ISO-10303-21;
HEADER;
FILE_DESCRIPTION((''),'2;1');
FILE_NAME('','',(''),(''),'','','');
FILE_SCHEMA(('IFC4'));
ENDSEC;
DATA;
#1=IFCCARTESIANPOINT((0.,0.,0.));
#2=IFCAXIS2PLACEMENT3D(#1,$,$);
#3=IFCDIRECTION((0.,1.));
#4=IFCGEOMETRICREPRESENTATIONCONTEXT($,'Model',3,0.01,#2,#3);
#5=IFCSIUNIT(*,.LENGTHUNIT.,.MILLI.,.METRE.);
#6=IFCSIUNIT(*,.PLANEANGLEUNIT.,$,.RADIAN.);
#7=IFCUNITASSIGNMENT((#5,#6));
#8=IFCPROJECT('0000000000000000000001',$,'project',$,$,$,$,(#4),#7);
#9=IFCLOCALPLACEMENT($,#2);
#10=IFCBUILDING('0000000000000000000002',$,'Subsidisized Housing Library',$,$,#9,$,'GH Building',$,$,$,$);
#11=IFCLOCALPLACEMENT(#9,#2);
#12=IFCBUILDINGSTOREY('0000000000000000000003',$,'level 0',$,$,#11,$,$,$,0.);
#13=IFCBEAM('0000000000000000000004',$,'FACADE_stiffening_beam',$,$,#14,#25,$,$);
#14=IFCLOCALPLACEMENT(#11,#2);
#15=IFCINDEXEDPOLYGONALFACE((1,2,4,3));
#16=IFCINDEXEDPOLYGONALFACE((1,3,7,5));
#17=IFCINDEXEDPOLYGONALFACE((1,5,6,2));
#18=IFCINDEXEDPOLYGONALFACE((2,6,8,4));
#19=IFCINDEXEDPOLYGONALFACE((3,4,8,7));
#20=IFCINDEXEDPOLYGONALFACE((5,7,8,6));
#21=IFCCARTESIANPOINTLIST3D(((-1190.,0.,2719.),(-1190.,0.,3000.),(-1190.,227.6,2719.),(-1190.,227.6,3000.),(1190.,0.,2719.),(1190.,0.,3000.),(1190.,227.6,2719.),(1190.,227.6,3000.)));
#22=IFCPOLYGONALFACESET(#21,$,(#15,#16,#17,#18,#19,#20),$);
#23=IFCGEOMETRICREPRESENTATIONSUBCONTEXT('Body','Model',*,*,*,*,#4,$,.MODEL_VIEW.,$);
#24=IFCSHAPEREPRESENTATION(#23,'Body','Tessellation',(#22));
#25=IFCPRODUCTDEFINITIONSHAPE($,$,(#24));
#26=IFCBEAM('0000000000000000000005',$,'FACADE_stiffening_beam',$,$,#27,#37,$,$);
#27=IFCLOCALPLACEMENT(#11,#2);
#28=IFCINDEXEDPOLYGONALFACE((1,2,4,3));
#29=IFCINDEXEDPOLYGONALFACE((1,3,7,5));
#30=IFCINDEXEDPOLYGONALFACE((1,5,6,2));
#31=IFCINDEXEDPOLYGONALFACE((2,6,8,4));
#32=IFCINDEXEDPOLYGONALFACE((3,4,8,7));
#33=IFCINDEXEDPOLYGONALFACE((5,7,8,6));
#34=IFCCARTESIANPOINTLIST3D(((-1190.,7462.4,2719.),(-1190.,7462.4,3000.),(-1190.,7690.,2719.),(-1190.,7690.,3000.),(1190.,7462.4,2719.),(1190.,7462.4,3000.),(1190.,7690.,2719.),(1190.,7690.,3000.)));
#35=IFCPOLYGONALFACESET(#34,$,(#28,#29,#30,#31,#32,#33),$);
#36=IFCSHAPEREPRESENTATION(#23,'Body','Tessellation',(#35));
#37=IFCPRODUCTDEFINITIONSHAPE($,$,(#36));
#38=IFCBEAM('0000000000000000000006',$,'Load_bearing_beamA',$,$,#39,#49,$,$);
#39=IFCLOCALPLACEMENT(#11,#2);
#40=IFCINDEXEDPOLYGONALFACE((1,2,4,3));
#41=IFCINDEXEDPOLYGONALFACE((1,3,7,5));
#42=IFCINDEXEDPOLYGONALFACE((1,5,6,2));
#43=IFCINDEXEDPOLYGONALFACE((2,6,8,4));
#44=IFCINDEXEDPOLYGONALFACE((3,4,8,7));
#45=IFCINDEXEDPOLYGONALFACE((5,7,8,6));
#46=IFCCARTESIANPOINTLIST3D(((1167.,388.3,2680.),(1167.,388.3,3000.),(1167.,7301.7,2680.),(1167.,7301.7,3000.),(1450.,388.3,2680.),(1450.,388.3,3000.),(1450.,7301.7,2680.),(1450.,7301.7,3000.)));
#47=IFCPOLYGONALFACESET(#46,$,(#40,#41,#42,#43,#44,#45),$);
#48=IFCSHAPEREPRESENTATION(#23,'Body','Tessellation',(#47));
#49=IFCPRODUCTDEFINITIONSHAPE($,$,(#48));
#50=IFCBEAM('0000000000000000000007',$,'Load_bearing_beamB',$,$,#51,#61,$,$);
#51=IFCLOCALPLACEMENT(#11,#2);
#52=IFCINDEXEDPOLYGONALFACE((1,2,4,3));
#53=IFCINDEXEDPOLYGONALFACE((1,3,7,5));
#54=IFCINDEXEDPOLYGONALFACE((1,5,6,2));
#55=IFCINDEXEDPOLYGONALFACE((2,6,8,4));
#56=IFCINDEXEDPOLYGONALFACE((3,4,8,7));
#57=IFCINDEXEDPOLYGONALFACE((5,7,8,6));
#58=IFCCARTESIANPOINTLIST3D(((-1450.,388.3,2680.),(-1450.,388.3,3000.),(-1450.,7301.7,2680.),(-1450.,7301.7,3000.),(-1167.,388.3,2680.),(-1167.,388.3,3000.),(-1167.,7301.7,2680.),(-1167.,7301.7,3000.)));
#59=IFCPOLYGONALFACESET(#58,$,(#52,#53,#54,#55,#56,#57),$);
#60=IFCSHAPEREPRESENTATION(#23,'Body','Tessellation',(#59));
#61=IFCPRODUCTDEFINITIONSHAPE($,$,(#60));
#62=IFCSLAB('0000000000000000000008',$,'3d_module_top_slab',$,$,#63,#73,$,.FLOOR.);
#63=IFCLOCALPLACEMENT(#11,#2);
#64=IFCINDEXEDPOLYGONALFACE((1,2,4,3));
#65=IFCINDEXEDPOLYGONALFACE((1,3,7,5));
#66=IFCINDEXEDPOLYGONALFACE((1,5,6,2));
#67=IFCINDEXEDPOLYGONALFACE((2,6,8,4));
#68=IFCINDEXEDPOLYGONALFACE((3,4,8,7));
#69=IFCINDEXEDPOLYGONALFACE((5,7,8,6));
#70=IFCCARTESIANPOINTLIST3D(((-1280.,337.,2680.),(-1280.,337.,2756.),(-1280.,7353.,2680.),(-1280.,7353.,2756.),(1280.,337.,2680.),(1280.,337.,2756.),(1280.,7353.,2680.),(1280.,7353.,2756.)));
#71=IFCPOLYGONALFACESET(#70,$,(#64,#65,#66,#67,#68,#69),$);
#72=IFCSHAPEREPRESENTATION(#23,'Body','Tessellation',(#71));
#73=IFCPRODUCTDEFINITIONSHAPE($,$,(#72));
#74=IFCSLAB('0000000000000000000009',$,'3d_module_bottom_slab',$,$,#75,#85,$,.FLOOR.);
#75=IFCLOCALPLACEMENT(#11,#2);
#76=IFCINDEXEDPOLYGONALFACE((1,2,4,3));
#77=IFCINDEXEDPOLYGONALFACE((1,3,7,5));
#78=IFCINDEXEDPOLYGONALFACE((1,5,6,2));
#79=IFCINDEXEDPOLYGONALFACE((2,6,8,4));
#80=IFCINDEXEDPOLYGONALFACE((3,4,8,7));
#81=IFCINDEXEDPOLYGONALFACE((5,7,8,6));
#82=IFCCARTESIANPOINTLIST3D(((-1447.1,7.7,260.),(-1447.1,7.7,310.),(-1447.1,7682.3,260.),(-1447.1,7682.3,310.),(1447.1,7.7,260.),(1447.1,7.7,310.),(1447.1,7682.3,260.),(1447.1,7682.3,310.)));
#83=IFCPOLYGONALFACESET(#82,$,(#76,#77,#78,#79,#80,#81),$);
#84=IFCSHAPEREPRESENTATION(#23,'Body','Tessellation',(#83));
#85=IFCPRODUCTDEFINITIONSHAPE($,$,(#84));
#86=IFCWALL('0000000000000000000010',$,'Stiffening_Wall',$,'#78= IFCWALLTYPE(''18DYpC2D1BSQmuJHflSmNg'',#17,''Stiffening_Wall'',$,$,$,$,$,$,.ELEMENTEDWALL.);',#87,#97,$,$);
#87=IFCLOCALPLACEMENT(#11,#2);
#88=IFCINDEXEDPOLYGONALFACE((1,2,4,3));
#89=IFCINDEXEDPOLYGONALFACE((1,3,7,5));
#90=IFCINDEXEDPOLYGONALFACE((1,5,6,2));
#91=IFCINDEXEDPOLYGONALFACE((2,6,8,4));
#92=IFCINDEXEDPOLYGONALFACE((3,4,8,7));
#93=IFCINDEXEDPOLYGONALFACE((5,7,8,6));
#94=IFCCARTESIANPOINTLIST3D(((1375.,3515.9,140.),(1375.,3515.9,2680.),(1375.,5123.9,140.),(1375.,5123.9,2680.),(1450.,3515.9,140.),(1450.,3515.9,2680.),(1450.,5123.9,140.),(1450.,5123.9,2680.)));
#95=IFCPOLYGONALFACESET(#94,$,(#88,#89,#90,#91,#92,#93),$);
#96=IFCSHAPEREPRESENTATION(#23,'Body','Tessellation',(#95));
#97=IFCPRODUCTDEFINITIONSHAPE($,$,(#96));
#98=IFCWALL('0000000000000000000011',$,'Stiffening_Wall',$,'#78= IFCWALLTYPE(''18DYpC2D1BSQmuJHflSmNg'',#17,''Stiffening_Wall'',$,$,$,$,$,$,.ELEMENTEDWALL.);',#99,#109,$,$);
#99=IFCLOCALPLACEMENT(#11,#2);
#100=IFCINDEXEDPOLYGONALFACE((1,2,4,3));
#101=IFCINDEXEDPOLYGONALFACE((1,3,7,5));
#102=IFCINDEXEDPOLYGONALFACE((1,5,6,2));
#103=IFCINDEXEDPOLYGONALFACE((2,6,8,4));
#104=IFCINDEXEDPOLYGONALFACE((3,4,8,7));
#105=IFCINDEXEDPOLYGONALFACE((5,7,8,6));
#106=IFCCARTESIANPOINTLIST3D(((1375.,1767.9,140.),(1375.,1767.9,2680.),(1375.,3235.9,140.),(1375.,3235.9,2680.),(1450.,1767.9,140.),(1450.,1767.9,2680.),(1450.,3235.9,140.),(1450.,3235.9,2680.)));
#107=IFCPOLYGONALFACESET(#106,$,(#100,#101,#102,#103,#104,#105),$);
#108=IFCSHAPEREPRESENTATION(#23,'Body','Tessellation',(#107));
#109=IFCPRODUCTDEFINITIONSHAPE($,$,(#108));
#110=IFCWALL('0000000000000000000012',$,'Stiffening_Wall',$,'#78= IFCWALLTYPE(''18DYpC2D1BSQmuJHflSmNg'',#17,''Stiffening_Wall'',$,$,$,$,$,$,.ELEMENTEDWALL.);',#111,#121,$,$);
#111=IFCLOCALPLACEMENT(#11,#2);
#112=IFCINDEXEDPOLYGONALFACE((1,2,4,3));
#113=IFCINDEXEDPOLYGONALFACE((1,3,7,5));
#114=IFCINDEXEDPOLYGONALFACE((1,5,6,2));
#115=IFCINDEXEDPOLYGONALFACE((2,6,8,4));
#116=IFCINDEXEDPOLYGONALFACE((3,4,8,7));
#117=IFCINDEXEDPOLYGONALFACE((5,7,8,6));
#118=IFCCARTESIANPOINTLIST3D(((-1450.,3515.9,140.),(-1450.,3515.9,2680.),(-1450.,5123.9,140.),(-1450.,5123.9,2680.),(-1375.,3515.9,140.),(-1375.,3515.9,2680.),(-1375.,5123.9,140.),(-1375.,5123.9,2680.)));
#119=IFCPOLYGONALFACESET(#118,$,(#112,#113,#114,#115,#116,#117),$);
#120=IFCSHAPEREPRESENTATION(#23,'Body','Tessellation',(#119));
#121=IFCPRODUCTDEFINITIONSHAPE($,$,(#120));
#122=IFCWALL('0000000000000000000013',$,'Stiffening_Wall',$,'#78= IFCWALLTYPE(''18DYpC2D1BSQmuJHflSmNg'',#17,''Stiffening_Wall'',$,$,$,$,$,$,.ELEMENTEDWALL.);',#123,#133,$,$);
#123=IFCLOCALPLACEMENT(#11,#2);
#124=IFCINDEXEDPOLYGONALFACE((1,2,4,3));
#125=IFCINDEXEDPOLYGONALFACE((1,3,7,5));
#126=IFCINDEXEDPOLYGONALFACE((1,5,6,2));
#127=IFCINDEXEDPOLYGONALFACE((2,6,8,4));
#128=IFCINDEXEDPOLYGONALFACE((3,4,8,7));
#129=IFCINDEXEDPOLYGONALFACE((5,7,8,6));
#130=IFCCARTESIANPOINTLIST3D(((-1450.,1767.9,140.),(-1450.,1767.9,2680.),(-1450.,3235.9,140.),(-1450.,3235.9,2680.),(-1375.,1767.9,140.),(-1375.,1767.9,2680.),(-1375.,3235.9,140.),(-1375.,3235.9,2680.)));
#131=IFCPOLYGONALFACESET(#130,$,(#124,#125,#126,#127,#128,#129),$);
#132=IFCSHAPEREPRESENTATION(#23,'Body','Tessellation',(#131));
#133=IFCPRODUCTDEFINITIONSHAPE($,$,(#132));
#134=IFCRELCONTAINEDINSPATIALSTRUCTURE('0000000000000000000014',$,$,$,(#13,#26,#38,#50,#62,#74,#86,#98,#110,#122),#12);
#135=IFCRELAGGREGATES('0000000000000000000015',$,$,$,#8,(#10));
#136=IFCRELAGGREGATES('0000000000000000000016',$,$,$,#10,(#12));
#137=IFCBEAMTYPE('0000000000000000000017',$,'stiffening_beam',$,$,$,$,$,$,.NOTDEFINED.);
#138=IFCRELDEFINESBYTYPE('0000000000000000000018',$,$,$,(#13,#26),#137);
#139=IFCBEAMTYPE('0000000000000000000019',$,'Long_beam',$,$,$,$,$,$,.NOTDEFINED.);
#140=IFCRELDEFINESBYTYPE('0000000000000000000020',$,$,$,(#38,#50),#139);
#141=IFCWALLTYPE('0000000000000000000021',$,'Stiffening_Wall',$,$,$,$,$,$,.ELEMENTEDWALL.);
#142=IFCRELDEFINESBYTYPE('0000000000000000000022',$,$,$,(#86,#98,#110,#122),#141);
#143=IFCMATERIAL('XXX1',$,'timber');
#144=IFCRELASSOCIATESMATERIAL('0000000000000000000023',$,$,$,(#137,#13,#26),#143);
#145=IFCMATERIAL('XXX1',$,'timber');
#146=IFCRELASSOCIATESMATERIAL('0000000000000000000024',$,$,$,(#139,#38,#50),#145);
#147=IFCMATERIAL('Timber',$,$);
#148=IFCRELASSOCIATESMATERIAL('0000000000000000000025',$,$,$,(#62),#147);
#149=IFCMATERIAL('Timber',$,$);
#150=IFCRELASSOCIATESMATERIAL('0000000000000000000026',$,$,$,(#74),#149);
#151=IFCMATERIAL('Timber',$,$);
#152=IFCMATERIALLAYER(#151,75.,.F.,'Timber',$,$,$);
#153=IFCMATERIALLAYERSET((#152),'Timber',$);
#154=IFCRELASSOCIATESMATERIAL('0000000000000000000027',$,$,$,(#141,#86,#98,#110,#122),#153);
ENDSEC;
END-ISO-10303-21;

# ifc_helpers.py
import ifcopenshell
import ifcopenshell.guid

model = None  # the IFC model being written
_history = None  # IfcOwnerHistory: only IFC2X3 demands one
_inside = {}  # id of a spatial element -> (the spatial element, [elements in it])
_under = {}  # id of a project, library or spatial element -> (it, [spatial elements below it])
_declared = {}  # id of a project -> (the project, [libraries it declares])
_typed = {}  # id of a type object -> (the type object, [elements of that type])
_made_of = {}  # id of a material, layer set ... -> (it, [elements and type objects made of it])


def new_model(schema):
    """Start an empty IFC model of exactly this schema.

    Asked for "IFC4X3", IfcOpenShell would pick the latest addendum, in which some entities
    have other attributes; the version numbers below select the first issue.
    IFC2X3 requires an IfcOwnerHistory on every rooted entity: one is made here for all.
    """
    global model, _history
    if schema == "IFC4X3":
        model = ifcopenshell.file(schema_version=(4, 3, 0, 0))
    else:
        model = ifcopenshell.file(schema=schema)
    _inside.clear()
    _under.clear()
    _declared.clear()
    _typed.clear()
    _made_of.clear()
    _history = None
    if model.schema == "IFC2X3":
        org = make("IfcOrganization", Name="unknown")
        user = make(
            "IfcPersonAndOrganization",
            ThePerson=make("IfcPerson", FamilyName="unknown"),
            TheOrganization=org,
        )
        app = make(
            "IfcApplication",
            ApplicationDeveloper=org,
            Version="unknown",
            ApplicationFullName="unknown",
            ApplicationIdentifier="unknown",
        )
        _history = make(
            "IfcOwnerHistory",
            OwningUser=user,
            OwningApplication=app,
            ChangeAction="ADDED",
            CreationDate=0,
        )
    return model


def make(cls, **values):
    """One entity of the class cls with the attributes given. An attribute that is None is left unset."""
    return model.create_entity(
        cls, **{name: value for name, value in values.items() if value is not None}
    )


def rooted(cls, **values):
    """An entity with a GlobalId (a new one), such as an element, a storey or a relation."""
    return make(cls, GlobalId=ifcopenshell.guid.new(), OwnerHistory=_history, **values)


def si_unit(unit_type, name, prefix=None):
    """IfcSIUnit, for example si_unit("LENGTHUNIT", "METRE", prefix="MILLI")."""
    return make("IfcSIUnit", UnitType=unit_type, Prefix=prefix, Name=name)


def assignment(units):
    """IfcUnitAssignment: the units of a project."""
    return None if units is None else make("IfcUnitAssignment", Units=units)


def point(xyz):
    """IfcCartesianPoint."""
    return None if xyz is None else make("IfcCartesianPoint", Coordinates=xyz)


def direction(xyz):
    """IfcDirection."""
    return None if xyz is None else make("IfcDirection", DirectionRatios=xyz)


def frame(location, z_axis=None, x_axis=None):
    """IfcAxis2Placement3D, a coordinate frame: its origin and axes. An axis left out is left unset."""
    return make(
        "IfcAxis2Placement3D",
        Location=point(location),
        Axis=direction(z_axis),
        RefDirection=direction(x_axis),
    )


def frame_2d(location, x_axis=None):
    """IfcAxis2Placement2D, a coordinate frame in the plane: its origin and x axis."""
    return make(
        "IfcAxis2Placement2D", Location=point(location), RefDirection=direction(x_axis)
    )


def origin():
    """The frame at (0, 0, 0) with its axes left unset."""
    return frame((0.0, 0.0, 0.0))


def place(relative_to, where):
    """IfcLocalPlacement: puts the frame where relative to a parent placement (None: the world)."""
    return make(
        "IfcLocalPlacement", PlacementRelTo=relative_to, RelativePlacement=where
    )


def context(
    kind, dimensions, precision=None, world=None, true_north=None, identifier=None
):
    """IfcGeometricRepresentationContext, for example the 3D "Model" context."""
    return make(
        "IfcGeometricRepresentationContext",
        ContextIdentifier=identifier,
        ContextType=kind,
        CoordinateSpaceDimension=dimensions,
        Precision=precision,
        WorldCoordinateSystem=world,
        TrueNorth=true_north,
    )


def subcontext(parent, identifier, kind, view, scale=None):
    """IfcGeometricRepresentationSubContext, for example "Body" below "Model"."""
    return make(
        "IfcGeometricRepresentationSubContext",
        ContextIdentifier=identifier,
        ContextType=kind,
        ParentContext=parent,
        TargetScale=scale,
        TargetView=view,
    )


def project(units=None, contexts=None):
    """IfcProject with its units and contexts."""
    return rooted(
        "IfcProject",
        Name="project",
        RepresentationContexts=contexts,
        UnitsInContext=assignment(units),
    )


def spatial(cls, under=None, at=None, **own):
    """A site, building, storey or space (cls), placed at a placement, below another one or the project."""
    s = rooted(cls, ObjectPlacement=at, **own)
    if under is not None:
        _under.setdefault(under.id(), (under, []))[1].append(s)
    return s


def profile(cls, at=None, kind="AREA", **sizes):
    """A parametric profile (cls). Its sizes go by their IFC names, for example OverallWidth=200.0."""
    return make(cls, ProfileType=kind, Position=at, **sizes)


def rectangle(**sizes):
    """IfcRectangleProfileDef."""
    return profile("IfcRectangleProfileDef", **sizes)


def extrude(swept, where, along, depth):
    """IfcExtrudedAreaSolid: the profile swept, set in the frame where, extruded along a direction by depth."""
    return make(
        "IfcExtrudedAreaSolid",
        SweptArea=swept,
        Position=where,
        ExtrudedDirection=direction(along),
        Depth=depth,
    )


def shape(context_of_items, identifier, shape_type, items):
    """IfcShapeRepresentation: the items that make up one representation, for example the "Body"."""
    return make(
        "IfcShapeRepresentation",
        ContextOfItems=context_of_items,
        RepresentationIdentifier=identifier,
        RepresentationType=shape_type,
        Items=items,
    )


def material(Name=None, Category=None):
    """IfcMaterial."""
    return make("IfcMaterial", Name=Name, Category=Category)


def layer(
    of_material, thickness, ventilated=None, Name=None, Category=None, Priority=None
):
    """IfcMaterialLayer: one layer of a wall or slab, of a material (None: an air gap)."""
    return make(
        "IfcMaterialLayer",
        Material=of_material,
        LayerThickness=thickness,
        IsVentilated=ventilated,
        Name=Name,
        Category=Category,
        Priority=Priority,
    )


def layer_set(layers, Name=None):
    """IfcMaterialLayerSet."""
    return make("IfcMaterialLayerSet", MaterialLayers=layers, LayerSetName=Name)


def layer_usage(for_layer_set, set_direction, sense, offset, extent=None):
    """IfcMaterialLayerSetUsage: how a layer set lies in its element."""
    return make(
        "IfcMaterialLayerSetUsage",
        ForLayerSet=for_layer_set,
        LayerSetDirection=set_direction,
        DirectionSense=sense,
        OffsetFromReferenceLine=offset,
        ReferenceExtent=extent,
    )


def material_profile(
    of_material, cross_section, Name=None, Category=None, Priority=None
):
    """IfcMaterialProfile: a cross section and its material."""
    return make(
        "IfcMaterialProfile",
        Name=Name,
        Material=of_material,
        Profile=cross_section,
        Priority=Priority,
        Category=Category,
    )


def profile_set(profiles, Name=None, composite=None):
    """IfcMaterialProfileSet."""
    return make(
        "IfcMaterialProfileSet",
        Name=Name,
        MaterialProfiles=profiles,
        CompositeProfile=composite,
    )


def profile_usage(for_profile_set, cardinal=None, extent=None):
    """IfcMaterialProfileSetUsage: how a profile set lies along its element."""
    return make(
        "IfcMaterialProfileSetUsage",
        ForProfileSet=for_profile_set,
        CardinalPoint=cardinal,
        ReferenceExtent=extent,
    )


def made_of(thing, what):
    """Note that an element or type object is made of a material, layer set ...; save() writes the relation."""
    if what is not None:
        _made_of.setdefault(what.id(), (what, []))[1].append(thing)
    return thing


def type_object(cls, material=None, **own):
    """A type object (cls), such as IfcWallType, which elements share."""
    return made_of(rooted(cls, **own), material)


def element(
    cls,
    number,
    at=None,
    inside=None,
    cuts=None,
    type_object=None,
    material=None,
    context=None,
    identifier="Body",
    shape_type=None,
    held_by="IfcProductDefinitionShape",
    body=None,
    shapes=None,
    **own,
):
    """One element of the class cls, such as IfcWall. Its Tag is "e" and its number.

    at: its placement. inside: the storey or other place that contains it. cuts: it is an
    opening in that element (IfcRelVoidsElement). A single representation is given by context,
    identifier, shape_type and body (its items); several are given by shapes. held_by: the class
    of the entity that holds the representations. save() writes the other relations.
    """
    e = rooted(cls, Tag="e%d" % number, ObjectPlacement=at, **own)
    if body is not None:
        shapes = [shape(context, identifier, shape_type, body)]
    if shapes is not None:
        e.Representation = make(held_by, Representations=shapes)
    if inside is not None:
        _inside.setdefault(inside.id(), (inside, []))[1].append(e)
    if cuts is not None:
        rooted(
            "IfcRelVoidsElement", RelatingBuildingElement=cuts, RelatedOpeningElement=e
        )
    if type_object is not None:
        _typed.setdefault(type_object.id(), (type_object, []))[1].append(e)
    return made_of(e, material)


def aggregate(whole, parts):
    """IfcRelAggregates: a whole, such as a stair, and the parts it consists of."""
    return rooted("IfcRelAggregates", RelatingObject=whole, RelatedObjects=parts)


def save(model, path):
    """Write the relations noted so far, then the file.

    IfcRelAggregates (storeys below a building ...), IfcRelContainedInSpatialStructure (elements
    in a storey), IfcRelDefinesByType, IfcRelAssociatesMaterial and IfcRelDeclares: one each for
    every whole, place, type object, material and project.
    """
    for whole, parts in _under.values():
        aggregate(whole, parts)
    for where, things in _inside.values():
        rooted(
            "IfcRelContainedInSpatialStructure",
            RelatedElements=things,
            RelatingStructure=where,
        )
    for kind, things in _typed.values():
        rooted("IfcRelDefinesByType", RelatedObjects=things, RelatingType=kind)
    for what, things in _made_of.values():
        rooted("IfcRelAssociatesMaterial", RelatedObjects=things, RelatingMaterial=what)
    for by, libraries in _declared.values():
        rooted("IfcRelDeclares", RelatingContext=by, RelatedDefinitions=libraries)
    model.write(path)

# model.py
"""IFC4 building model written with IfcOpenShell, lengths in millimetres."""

from ifc_helpers import new_model, si_unit, direction, frame, frame_2d, origin, place, context, subcontext, project, spatial, rectangle, extrude, material, layer, layer_set, layer_usage, material_profile, profile_set, profile_usage, type_object, element, save


model = new_model("IFC4")

# Units and contexts
model_context = context("Model", 3, precision=0.01, world=origin(), true_north=direction((0.0, 1.0)))
body_context = subcontext(model_context, "Body", "Model", "MODEL_VIEW")
ifc_project = project(units=[si_unit("LENGTHUNIT", "METRE", prefix="MILLI"), si_unit("PLANEANGLEUNIT", "RADIAN")], contexts=[model_context])

# Building, storey
building_placement = place(None, origin())
building = spatial("IfcBuilding", under=ifc_project, at=building_placement, Name="Subsidisized Housing Library", LongName="GH Building")
storey_placement = place(building_placement, origin())
storey = spatial("IfcBuildingStorey", under=building, at=storey_placement, Name="level 0", Elevation=0.0)

# Beams
ifc_material_1 = material(Name="XXX1", Category="timber")
ifc_material_profile_1 = material_profile(ifc_material_1, rectangle(XDim=227.6, YDim=281.0, at=frame_2d((113.8, 140.5))), Name="impleniaMaterialA", Priority=0)
ifc_profile_set_1 = profile_set([ifc_material_profile_1], Name="stiffening_beam")
ifc_profile_usage_1 = profile_usage(ifc_profile_set_1, cardinal=3)
beam_type_1 = type_object("IfcBeamType", Name="stiffening_beam", PredefinedType="NOTDEFINED", material=ifc_profile_set_1)
for number, where, z_axis, x_axis, name in (
    (1, (-1190.0, 0.0, 2719.0), (1.0, 0.0, 0.0), (0.0, 1.0, 0.0), "FACADE_stiffening_beam"),
    (2, (1190.0, 7690.0, 2719.0), (-1.0, 0.0, 0.0), (0.0, -1.0, 0.0), "FACADE_stiffening_beam"),
):
    element("IfcBeam", number, at=place(storey_placement, frame(where, z_axis=z_axis, x_axis=x_axis)), inside=storey, type_object=beam_type_1, material=ifc_profile_usage_1, Name=name, context=body_context, shape_type="AdvancedSweptSolid", body=[
        extrude(rectangle(XDim=227.6, YDim=281.0, at=frame_2d((113.8, 140.5))), None, (0.0, 0.0, 1.0), 2380.0),
    ])
ifc_material_2 = material(Name="XXX1", Category="timber")
ifc_material_profile_2 = material_profile(ifc_material_2, rectangle(XDim=283.0, YDim=320.0), Name="impleniaMaterialA", Priority=0)
ifc_profile_set_2 = profile_set([ifc_material_profile_2], Name="Long_beam")
ifc_profile_usage_2 = profile_usage(ifc_profile_set_2, cardinal=9)
beam_type_2 = type_object("IfcBeamType", Name="Long_beam", PredefinedType="NOTDEFINED", material=ifc_profile_set_2)
beam_1_placement = place(storey_placement, frame((1450.0, 388.3, 3000.0), z_axis=(0.0, 1.0, 0.0), x_axis=(-1.0, 0.0, 0.0)))
element("IfcBeam", 3, at=beam_1_placement, inside=storey, type_object=beam_type_2, material=ifc_profile_usage_2, Name="Load_bearing_beamA", context=body_context, shape_type="AdvancedSweptSolid", body=[
    extrude(rectangle(XDim=283.0, YDim=320.0), frame((141.5, -160.0, 0.0)), (0.0, 0.0, 1.0), 6913.3),
])
ifc_profile_usage_3 = profile_usage(ifc_profile_set_2, cardinal=7)
beam_2_placement = place(storey_placement, frame((-1450.0, 388.3, 3000.0), z_axis=(0.0, 1.0, 0.0), x_axis=(-1.0, 0.0, 0.0)))
element("IfcBeam", 4, at=beam_2_placement, inside=storey, type_object=beam_type_2, material=ifc_profile_usage_3, Name="Load_bearing_beamB", context=body_context, shape_type="AdvancedSweptSolid", body=[
    extrude(rectangle(XDim=283.0, YDim=320.0), frame((-141.5, -160.0, 0.0)), (0.0, 0.0, 1.0), 6913.3),
])

# Slabs
ifc_material_3 = material(Name="Timber")
slab_1_placement = place(None, origin())
element("IfcSlab", 5, at=slab_1_placement, inside=storey, material=ifc_material_3, Name="3d_module_top_slab", PredefinedType="FLOOR", context=body_context, shape_type="SolidModel", body=[
    extrude(rectangle(XDim=7016.0, YDim=2560.0), frame((0.0, 3845.0, 2680.0), z_axis=(0.0, 0.0, 1.0), x_axis=(0.0, 1.0, 0.0)), (0.0, 0.0, 1.0), 76.0),
])
ifc_material_4 = material(Name="Timber")
slab_2_placement = place(None, origin())
element("IfcSlab", 6, at=slab_2_placement, inside=storey, material=ifc_material_4, Name="3d_module_bottom_slab", PredefinedType="FLOOR", context=body_context, shape_type="SolidModel", body=[
    extrude(rectangle(XDim=2894.2, YDim=7674.6), frame((0.0, 3845.0, 260.0)), (0.0, 0.0, 1.0), 50.0),
])

# Walls
ifc_material_5 = material(Name="Timber")
ifc_layer = layer(ifc_material_5, 75.0, ventilated=False, Name="Timber")
ifc_layer_set = layer_set([ifc_layer], Name="Timber")
ifc_layer_usage_1 = layer_usage(ifc_layer_set, "AXIS2", "POSITIVE", -37.5)
wall_type = type_object("IfcWallType", Name="Stiffening_Wall", PredefinedType="ELEMENTEDWALL", material=ifc_layer_set)
wall_1_placement = place(storey_placement, frame((1412.5, 3515.9, 140.0), z_axis=(0.0, 0.0, 1.0), x_axis=(0.0, 1.0, 0.0)))
element("IfcWall", 7, at=wall_1_placement, inside=storey, type_object=wall_type, material=ifc_layer_usage_1, Name="Stiffening_Wall", ObjectType="#78= IFCWALLTYPE('18DYpC2D1BSQmuJHflSmNg',#17,'Stiffening_Wall',$,$,$,$,$,$,.ELEMENTEDWALL.);", context=body_context, shape_type="AdvancedSweptSolid", body=[
    extrude(rectangle(XDim=1608.0, YDim=75.0, at=frame_2d((804.0, 0.0))), None, (0.0, 0.0, 1.0), 2540.0),
])
ifc_layer_usage_2 = layer_usage(ifc_layer_set, "AXIS2", "POSITIVE", -37.5)
wall_2_placement = place(storey_placement, frame((1412.5, 1767.9, 140.0), z_axis=(0.0, 0.0, 1.0), x_axis=(0.0, 1.0, 0.0)))
element("IfcWall", 8, at=wall_2_placement, inside=storey, type_object=wall_type, material=ifc_layer_usage_2, Name="Stiffening_Wall", ObjectType="#78= IFCWALLTYPE('18DYpC2D1BSQmuJHflSmNg',#17,'Stiffening_Wall',$,$,$,$,$,$,.ELEMENTEDWALL.);", context=body_context, shape_type="AdvancedSweptSolid", body=[
    extrude(rectangle(XDim=1468.0, YDim=75.0, at=frame_2d((734.0, 0.0))), None, (0.0, 0.0, 1.0), 2540.0),
])
ifc_layer_usage_3 = layer_usage(ifc_layer_set, "AXIS2", "POSITIVE", -37.5)
wall_3_placement = place(storey_placement, frame((-1412.5, 3515.9, 140.0), z_axis=(0.0, 0.0, 1.0), x_axis=(0.0, 1.0, 0.0)))
element("IfcWall", 9, at=wall_3_placement, inside=storey, type_object=wall_type, material=ifc_layer_usage_3, Name="Stiffening_Wall", ObjectType="#78= IFCWALLTYPE('18DYpC2D1BSQmuJHflSmNg',#17,'Stiffening_Wall',$,$,$,$,$,$,.ELEMENTEDWALL.);", context=body_context, shape_type="AdvancedSweptSolid", body=[
    extrude(rectangle(XDim=1608.0, YDim=75.0, at=frame_2d((804.0, 0.0))), None, (0.0, 0.0, 1.0), 2540.0),
])
ifc_layer_usage_4 = layer_usage(ifc_layer_set, "AXIS2", "POSITIVE", -37.5)
wall_4_placement = place(storey_placement, frame((-1412.5, 1767.9, 140.0), z_axis=(0.0, 0.0, 1.0), x_axis=(0.0, 1.0, 0.0)))
element("IfcWall", 10, at=wall_4_placement, inside=storey, type_object=wall_type, material=ifc_layer_usage_4, Name="Stiffening_Wall", ObjectType="#78= IFCWALLTYPE('18DYpC2D1BSQmuJHflSmNg',#17,'Stiffening_Wall',$,$,$,$,$,$,.ELEMENTEDWALL.);", context=body_context, shape_type="AdvancedSweptSolid", body=[
    extrude(rectangle(XDim=1468.0, YDim=75.0, at=frame_2d((734.0, 0.0))), None, (0.0, 0.0, 1.0), 2540.0),
])

save(model, "model.ifc")
